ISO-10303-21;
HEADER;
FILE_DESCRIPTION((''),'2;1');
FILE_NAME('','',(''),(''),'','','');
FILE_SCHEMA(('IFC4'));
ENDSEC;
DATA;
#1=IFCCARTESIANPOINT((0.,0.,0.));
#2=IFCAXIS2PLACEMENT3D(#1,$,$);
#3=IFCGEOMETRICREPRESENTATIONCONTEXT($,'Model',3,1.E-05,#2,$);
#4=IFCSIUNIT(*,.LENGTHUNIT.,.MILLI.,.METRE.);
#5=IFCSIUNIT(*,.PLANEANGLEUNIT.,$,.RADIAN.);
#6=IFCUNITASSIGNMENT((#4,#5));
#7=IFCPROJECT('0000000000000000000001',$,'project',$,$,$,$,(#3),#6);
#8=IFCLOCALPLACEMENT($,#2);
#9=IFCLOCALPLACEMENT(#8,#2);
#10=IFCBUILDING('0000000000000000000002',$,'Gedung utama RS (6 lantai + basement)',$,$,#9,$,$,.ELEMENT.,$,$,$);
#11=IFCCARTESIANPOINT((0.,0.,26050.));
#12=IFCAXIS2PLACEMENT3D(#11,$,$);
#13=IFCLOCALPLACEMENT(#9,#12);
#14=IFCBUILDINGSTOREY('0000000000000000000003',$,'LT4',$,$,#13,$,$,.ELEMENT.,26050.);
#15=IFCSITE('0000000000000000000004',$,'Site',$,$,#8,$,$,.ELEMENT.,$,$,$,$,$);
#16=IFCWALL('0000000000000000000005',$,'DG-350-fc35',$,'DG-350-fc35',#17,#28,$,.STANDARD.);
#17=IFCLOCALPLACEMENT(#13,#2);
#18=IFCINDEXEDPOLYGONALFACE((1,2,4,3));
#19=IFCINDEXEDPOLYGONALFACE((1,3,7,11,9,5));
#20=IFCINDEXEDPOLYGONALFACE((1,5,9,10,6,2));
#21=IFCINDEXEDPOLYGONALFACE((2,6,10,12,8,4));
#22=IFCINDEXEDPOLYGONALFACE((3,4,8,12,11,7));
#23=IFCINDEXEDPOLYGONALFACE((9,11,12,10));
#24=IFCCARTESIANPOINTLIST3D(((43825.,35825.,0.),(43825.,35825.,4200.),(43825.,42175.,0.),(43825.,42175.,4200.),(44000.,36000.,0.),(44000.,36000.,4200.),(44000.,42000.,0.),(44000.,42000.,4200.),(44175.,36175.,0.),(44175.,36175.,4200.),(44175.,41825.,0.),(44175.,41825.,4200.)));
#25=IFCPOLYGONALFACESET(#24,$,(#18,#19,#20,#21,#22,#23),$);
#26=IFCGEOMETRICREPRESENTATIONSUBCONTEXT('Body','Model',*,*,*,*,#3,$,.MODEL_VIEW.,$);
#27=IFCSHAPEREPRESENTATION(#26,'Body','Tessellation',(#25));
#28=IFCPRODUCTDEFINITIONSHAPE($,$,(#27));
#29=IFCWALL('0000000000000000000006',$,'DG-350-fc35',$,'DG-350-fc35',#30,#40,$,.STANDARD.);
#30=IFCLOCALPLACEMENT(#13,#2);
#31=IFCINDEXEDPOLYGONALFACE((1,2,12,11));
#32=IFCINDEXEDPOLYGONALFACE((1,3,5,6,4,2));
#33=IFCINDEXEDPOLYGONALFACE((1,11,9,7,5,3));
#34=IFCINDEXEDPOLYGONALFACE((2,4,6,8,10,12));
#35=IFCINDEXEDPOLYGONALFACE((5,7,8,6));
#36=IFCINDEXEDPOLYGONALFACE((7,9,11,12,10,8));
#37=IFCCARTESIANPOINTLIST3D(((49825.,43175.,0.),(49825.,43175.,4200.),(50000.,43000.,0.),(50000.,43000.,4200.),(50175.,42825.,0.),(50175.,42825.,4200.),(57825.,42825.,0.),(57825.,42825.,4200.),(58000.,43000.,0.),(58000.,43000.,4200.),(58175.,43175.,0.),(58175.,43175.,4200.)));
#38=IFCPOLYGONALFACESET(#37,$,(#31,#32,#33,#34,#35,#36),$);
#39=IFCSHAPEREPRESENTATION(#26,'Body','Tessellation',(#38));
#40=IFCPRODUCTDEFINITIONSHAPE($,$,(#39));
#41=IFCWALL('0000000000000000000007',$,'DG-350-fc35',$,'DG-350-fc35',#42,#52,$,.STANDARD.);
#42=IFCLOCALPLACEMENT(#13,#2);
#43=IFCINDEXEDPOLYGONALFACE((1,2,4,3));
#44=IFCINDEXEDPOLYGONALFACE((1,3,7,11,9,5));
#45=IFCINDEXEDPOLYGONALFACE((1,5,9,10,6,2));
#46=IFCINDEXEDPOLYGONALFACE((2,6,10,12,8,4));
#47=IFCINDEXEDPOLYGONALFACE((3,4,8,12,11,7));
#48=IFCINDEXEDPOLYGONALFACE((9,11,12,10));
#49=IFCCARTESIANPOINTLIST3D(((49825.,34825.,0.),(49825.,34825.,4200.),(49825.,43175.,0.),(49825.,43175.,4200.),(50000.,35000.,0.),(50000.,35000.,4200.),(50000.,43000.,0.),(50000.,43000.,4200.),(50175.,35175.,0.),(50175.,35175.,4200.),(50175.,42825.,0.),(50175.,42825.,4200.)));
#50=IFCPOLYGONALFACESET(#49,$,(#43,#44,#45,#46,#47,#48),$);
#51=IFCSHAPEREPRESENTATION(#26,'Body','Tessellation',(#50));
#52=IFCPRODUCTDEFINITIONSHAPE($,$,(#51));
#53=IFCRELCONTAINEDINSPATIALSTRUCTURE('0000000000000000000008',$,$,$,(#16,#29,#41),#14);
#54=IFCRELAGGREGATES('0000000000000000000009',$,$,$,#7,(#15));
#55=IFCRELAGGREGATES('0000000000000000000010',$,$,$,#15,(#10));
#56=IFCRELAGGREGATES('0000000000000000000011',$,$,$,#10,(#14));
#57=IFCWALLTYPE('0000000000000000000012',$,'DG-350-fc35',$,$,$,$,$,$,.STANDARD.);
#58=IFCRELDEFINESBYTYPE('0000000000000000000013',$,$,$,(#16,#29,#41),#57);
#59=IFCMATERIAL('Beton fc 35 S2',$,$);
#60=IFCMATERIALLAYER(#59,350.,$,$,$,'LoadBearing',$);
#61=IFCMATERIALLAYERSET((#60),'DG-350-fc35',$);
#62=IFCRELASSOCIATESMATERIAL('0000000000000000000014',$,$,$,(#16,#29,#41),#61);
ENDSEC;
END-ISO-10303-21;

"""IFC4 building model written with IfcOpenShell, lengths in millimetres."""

from ifc_helpers import new_model, si_unit, frame, origin, place, context, subcontext, project, spatial, polyline, outline, extrude, material, layer, layer_set, layer_usage, type_object, element, save


model = new_model("IFC4")

# Units and contexts
model_context = context("Model", 3, precision=1e-05, world=origin())
body_context = subcontext(model_context, "Body", "Model", "MODEL_VIEW")
ifc_project = project(units=[si_unit("LENGTHUNIT", "METRE", prefix="MILLI"), si_unit("PLANEANGLEUNIT", "RADIAN")], contexts=[model_context])

# Site, building, storey
site_placement = place(None, origin())
site = spatial("IfcSite", under=ifc_project, at=site_placement, Name="Site", CompositionType="ELEMENT")
building_placement = place(site_placement, origin())
building = spatial("IfcBuilding", under=site, at=building_placement, Name="Gedung utama RS (6 lantai + basement)", CompositionType="ELEMENT")
storey_placement = place(building_placement, frame((0.0, 0.0, 26050.0)))
storey = spatial("IfcBuildingStorey", under=building, at=storey_placement, Name="LT4", CompositionType="ELEMENT", Elevation=26050.0)

# Walls
ifc_material_1 = material(Name="Beton fc 35 S2")
ifc_layer = layer(ifc_material_1, 350.0, Category="LoadBearing")
ifc_layer_set = layer_set([ifc_layer], Name="DG-350-fc35")
ifc_layer_usage = layer_usage(ifc_layer_set, "AXIS2", "NEGATIVE", 175.0)
wall_type = type_object("IfcWallType", Name="DG-350-fc35", PredefinedType="STANDARD")
wall_1_placement = place(storey_placement, frame((44000.0, 42000.0, 0.0), z_axis=(0.0, 0.0, 1.0), x_axis=(0.0, -1.0, 0.0)))
element("IfcWall", 1, at=wall_1_placement, inside=storey, type_object=wall_type, material=ifc_layer_usage, Name="DG-350-fc35", ObjectType="DG-350-fc35", PredefinedType="STANDARD", context=body_context, shape_type="SweptSolid", body=[
    extrude(outline(polyline([(-175.0, -175.0), (0.0, 0.0), (175.0, 175.0), (5825.0, 175.0), (6000.0, 0.0), (6175.0, -175.0), (-175.0, -175.0)])), origin(), (0.0, 0.0, 1.0), 4200.0),
])
for number, where, z_axis, x_axis, name in (
    (2, (58000.0, 43000.0, 0.0), (0.0, 0.0, 1.0), (-1.0, 0.0, 0.0), "DG-350-fc35"),
    (3, (50000.0, 43000.0, 0.0), (0.0, 0.0, 1.0), (0.0, -1.0, 0.0), "DG-350-fc35"),
):
    element("IfcWall", number, at=place(storey_placement, frame(where, z_axis=z_axis, x_axis=x_axis)), inside=storey, type_object=wall_type, material=ifc_layer_usage, Name=name, ObjectType="DG-350-fc35", PredefinedType="STANDARD", context=body_context, shape_type="SweptSolid", body=[
        extrude(outline(polyline([(-175.0, -175.0), (0.0, 0.0), (175.0, 175.0), (7825.0, 175.0), (8000.0, 0.0), (8175.0, -175.0), (-175.0, -175.0)])), origin(), (0.0, 0.0, 1.0), 4200.0),
    ])

save(model, "model.ifc")
